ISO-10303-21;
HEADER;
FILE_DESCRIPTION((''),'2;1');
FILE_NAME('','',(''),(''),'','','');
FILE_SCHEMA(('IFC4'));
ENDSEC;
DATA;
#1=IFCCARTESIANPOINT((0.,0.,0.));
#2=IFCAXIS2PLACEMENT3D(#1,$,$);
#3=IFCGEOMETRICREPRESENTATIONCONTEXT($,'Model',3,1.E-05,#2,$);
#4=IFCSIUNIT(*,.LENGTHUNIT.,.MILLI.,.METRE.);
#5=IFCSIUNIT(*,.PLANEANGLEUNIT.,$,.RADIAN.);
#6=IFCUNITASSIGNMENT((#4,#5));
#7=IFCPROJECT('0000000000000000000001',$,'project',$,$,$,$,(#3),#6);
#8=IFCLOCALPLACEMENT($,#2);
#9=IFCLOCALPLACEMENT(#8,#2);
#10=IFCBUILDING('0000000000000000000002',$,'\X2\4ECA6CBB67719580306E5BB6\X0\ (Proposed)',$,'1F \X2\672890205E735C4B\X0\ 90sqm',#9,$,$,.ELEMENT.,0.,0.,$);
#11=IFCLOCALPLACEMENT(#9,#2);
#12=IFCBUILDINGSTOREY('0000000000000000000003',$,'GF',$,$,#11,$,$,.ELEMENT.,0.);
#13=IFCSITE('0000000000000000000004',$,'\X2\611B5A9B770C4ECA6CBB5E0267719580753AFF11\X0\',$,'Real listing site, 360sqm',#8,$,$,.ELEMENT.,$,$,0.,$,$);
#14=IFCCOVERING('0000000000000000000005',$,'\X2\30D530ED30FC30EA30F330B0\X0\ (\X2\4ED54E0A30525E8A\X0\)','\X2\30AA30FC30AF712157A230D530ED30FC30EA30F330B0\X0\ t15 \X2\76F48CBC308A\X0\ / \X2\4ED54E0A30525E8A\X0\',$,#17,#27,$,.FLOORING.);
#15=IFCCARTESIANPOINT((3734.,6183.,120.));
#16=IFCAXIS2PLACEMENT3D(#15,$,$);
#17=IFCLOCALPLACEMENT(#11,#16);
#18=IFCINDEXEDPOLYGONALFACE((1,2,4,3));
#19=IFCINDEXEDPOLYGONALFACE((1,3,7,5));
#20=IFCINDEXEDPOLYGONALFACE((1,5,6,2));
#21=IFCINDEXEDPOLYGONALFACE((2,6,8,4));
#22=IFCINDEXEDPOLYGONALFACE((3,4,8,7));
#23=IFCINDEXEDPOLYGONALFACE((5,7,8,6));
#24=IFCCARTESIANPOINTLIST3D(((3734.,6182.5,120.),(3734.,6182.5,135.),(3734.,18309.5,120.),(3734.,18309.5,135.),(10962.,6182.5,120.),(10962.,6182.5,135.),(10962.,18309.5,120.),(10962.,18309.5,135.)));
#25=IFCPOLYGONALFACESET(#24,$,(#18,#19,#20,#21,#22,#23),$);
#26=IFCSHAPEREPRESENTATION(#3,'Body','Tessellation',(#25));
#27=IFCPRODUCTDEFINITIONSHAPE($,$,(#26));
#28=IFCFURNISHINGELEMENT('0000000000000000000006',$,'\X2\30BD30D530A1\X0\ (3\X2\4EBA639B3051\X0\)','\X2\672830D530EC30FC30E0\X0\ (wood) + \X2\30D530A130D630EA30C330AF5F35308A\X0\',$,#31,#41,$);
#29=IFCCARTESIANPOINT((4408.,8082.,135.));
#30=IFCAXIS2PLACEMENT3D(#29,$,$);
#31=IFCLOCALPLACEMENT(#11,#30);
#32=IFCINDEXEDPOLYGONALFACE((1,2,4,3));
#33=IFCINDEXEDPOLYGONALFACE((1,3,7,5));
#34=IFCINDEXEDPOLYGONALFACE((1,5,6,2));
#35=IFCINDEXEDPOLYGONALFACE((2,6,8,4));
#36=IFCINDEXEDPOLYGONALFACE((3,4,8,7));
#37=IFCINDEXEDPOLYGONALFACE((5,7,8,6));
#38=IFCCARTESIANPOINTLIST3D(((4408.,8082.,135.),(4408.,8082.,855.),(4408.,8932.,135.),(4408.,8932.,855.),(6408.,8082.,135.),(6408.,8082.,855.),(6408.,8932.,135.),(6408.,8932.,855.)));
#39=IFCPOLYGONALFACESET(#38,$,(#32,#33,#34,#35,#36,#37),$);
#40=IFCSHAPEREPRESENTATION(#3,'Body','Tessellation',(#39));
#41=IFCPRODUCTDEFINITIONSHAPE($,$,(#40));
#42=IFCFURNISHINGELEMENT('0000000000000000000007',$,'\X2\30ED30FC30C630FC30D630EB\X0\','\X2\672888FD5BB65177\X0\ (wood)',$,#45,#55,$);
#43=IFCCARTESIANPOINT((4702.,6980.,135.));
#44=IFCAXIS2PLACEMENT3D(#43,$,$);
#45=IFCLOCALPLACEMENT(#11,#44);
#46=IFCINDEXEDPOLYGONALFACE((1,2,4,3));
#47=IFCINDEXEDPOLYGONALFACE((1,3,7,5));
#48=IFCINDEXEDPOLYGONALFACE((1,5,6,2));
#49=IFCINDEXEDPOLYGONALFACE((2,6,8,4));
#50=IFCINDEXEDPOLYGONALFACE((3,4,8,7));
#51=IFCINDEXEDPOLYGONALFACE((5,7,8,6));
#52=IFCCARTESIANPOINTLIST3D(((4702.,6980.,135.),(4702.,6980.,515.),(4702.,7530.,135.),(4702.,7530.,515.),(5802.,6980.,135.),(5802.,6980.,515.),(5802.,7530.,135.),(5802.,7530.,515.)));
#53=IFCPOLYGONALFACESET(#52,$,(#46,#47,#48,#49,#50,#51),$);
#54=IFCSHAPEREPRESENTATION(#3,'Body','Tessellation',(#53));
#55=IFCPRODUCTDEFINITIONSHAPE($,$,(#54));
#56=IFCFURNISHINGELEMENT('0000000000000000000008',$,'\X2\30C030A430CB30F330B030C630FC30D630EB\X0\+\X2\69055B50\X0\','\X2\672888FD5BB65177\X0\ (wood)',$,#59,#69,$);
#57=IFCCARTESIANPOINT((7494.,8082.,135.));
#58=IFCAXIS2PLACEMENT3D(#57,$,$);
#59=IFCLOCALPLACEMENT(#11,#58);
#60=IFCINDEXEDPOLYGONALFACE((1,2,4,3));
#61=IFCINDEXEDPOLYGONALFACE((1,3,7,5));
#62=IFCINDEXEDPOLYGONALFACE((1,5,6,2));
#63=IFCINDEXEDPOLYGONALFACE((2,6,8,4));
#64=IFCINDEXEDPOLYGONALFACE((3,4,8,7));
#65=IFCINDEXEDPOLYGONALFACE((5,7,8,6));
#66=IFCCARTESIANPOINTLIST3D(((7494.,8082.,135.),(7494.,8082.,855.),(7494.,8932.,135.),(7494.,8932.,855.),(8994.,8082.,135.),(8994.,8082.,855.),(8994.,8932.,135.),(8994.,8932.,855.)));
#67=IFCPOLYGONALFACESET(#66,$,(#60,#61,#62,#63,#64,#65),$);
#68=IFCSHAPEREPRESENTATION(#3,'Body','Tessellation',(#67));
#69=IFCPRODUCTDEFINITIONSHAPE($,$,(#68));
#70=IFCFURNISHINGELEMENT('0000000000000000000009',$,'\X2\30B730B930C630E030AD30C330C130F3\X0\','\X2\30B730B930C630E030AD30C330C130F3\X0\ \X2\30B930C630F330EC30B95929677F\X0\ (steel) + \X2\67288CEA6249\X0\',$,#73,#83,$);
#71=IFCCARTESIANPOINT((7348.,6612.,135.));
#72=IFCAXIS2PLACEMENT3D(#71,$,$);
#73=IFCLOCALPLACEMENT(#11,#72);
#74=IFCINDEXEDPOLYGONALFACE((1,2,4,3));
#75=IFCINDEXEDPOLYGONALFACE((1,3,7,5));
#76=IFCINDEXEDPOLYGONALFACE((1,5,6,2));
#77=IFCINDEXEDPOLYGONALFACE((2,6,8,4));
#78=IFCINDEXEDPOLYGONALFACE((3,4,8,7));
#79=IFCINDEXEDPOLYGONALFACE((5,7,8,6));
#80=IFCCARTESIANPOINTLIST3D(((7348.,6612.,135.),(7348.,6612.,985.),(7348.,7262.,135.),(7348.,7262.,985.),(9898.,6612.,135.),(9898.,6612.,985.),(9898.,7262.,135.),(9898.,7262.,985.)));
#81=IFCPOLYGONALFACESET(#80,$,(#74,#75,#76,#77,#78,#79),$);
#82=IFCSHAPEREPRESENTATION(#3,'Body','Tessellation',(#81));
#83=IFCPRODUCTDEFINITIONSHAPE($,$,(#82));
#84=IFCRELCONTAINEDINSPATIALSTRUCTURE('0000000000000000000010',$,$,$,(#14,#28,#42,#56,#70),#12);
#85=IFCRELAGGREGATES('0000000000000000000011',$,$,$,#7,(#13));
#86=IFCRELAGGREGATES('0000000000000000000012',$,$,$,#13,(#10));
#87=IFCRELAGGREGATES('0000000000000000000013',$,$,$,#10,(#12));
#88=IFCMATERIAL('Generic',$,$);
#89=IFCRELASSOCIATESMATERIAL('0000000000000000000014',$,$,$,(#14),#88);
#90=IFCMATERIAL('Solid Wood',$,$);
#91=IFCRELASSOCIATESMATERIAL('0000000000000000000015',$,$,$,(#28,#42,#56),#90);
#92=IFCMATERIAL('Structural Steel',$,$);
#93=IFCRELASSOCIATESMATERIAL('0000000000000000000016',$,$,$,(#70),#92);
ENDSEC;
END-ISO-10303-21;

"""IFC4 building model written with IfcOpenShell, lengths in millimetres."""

from ifc_helpers import new_model, si_unit, frame, frame_2d, origin, place, context, project, spatial, rectangle, extrude, material, element, save


model = new_model("IFC4")

# Units and contexts
model_context = context("Model", 3, precision=1e-05, world=origin())
ifc_project = project(units=[si_unit("LENGTHUNIT", "METRE", prefix="MILLI"), si_unit("PLANEANGLEUNIT", "RADIAN")], contexts=[model_context])

# Site, building, storey
site_placement = place(None, origin())
site = spatial("IfcSite", under=ifc_project, at=site_placement, Name="愛媛県今治市東門町１", ObjectType="Real listing site, 360sqm", CompositionType="ELEMENT", RefElevation=0.0)
building_placement = place(site_placement, origin())
building = spatial("IfcBuilding", under=site, at=building_placement, Name="今治東門の家 (Proposed)", ObjectType="1F 木造平屋 90sqm", CompositionType="ELEMENT", ElevationOfRefHeight=0.0, ElevationOfTerrain=0.0)
storey_placement = place(building_placement, origin())
storey = spatial("IfcBuildingStorey", under=building, at=storey_placement, Name="GF", CompositionType="ELEMENT", Elevation=0.0)

# Shared definitions
ifc_material_1 = material(Name="Solid Wood")

# Shared definitions
ifc_material_2 = material(Name="Structural Steel")

# Covering
ifc_material_3 = material(Name="Generic")
covering_placement = place(storey_placement, frame((3734.0, 6183.0, 120.0)))
element("IfcCovering", 1, at=covering_placement, inside=storey, material=ifc_material_3, Name="フローリング (仕上げ床)", Description="オーク無垢フローリング t15 直貼り / 仕上げ床", PredefinedType="FLOORING", context=model_context, shape_type="SweptSolid", body=[
    extrude(rectangle(XDim=7228.0, YDim=12127.0, at=frame_2d((3614.0, 6063.0))), frame((3734.0, 6183.0, 120.0)), (0.0, 0.0, 1.0), 15.0),
])

# Furnishing elements
furnishing_1_placement = place(storey_placement, frame((4408.0, 8082.0, 135.0)))
element("IfcFurnishingElement", 2, at=furnishing_1_placement, inside=storey, material=ifc_material_1, Name="ソファ (3人掛け)", Description="木フレーム (wood) + ファブリック張り", context=model_context, shape_type="SweptSolid", body=[
    extrude(rectangle(XDim=2000.0, YDim=850.0, at=frame_2d((1000.0, 425.0))), frame((4408.0, 8082.0, 135.0)), (0.0, 0.0, 1.0), 720.0),
])
furnishing_2_placement = place(storey_placement, frame((4702.0, 6980.0, 135.0)))
element("IfcFurnishingElement", 3, at=furnishing_2_placement, inside=storey, material=ifc_material_1, Name="ローテーブル", Description="木製家具 (wood)", context=model_context, shape_type="SweptSolid", body=[
    extrude(rectangle(XDim=1100.0, YDim=550.0, at=frame_2d((550.0, 275.0))), frame((4702.0, 6980.0, 135.0)), (0.0, 0.0, 1.0), 380.0),
])
furnishing_3_placement = place(storey_placement, frame((7494.0, 8082.0, 135.0)))
element("IfcFurnishingElement", 4, at=furnishing_3_placement, inside=storey, material=ifc_material_1, Name="ダイニングテーブル+椅子", Description="木製家具 (wood)", context=model_context, shape_type="SweptSolid", body=[
    extrude(rectangle(XDim=1500.0, YDim=850.0, at=frame_2d((750.0, 425.0))), frame((7494.0, 8082.0, 135.0)), (0.0, 0.0, 1.0), 720.0),
])
furnishing_4_placement = place(storey_placement, frame((7348.0, 6612.0, 135.0)))
element("IfcFurnishingElement", 5, at=furnishing_4_placement, inside=storey, material=ifc_material_2, Name="システムキッチン", Description="システムキッチン ステンレス天板 (steel) + 木質扉", context=model_context, shape_type="SweptSolid", body=[
    extrude(rectangle(XDim=2550.0, YDim=650.0, at=frame_2d((1275.0, 325.0))), frame((7348.0, 6612.0, 135.0)), (0.0, 0.0, 1.0), 850.0),
])

save(model, "model.ifc")
